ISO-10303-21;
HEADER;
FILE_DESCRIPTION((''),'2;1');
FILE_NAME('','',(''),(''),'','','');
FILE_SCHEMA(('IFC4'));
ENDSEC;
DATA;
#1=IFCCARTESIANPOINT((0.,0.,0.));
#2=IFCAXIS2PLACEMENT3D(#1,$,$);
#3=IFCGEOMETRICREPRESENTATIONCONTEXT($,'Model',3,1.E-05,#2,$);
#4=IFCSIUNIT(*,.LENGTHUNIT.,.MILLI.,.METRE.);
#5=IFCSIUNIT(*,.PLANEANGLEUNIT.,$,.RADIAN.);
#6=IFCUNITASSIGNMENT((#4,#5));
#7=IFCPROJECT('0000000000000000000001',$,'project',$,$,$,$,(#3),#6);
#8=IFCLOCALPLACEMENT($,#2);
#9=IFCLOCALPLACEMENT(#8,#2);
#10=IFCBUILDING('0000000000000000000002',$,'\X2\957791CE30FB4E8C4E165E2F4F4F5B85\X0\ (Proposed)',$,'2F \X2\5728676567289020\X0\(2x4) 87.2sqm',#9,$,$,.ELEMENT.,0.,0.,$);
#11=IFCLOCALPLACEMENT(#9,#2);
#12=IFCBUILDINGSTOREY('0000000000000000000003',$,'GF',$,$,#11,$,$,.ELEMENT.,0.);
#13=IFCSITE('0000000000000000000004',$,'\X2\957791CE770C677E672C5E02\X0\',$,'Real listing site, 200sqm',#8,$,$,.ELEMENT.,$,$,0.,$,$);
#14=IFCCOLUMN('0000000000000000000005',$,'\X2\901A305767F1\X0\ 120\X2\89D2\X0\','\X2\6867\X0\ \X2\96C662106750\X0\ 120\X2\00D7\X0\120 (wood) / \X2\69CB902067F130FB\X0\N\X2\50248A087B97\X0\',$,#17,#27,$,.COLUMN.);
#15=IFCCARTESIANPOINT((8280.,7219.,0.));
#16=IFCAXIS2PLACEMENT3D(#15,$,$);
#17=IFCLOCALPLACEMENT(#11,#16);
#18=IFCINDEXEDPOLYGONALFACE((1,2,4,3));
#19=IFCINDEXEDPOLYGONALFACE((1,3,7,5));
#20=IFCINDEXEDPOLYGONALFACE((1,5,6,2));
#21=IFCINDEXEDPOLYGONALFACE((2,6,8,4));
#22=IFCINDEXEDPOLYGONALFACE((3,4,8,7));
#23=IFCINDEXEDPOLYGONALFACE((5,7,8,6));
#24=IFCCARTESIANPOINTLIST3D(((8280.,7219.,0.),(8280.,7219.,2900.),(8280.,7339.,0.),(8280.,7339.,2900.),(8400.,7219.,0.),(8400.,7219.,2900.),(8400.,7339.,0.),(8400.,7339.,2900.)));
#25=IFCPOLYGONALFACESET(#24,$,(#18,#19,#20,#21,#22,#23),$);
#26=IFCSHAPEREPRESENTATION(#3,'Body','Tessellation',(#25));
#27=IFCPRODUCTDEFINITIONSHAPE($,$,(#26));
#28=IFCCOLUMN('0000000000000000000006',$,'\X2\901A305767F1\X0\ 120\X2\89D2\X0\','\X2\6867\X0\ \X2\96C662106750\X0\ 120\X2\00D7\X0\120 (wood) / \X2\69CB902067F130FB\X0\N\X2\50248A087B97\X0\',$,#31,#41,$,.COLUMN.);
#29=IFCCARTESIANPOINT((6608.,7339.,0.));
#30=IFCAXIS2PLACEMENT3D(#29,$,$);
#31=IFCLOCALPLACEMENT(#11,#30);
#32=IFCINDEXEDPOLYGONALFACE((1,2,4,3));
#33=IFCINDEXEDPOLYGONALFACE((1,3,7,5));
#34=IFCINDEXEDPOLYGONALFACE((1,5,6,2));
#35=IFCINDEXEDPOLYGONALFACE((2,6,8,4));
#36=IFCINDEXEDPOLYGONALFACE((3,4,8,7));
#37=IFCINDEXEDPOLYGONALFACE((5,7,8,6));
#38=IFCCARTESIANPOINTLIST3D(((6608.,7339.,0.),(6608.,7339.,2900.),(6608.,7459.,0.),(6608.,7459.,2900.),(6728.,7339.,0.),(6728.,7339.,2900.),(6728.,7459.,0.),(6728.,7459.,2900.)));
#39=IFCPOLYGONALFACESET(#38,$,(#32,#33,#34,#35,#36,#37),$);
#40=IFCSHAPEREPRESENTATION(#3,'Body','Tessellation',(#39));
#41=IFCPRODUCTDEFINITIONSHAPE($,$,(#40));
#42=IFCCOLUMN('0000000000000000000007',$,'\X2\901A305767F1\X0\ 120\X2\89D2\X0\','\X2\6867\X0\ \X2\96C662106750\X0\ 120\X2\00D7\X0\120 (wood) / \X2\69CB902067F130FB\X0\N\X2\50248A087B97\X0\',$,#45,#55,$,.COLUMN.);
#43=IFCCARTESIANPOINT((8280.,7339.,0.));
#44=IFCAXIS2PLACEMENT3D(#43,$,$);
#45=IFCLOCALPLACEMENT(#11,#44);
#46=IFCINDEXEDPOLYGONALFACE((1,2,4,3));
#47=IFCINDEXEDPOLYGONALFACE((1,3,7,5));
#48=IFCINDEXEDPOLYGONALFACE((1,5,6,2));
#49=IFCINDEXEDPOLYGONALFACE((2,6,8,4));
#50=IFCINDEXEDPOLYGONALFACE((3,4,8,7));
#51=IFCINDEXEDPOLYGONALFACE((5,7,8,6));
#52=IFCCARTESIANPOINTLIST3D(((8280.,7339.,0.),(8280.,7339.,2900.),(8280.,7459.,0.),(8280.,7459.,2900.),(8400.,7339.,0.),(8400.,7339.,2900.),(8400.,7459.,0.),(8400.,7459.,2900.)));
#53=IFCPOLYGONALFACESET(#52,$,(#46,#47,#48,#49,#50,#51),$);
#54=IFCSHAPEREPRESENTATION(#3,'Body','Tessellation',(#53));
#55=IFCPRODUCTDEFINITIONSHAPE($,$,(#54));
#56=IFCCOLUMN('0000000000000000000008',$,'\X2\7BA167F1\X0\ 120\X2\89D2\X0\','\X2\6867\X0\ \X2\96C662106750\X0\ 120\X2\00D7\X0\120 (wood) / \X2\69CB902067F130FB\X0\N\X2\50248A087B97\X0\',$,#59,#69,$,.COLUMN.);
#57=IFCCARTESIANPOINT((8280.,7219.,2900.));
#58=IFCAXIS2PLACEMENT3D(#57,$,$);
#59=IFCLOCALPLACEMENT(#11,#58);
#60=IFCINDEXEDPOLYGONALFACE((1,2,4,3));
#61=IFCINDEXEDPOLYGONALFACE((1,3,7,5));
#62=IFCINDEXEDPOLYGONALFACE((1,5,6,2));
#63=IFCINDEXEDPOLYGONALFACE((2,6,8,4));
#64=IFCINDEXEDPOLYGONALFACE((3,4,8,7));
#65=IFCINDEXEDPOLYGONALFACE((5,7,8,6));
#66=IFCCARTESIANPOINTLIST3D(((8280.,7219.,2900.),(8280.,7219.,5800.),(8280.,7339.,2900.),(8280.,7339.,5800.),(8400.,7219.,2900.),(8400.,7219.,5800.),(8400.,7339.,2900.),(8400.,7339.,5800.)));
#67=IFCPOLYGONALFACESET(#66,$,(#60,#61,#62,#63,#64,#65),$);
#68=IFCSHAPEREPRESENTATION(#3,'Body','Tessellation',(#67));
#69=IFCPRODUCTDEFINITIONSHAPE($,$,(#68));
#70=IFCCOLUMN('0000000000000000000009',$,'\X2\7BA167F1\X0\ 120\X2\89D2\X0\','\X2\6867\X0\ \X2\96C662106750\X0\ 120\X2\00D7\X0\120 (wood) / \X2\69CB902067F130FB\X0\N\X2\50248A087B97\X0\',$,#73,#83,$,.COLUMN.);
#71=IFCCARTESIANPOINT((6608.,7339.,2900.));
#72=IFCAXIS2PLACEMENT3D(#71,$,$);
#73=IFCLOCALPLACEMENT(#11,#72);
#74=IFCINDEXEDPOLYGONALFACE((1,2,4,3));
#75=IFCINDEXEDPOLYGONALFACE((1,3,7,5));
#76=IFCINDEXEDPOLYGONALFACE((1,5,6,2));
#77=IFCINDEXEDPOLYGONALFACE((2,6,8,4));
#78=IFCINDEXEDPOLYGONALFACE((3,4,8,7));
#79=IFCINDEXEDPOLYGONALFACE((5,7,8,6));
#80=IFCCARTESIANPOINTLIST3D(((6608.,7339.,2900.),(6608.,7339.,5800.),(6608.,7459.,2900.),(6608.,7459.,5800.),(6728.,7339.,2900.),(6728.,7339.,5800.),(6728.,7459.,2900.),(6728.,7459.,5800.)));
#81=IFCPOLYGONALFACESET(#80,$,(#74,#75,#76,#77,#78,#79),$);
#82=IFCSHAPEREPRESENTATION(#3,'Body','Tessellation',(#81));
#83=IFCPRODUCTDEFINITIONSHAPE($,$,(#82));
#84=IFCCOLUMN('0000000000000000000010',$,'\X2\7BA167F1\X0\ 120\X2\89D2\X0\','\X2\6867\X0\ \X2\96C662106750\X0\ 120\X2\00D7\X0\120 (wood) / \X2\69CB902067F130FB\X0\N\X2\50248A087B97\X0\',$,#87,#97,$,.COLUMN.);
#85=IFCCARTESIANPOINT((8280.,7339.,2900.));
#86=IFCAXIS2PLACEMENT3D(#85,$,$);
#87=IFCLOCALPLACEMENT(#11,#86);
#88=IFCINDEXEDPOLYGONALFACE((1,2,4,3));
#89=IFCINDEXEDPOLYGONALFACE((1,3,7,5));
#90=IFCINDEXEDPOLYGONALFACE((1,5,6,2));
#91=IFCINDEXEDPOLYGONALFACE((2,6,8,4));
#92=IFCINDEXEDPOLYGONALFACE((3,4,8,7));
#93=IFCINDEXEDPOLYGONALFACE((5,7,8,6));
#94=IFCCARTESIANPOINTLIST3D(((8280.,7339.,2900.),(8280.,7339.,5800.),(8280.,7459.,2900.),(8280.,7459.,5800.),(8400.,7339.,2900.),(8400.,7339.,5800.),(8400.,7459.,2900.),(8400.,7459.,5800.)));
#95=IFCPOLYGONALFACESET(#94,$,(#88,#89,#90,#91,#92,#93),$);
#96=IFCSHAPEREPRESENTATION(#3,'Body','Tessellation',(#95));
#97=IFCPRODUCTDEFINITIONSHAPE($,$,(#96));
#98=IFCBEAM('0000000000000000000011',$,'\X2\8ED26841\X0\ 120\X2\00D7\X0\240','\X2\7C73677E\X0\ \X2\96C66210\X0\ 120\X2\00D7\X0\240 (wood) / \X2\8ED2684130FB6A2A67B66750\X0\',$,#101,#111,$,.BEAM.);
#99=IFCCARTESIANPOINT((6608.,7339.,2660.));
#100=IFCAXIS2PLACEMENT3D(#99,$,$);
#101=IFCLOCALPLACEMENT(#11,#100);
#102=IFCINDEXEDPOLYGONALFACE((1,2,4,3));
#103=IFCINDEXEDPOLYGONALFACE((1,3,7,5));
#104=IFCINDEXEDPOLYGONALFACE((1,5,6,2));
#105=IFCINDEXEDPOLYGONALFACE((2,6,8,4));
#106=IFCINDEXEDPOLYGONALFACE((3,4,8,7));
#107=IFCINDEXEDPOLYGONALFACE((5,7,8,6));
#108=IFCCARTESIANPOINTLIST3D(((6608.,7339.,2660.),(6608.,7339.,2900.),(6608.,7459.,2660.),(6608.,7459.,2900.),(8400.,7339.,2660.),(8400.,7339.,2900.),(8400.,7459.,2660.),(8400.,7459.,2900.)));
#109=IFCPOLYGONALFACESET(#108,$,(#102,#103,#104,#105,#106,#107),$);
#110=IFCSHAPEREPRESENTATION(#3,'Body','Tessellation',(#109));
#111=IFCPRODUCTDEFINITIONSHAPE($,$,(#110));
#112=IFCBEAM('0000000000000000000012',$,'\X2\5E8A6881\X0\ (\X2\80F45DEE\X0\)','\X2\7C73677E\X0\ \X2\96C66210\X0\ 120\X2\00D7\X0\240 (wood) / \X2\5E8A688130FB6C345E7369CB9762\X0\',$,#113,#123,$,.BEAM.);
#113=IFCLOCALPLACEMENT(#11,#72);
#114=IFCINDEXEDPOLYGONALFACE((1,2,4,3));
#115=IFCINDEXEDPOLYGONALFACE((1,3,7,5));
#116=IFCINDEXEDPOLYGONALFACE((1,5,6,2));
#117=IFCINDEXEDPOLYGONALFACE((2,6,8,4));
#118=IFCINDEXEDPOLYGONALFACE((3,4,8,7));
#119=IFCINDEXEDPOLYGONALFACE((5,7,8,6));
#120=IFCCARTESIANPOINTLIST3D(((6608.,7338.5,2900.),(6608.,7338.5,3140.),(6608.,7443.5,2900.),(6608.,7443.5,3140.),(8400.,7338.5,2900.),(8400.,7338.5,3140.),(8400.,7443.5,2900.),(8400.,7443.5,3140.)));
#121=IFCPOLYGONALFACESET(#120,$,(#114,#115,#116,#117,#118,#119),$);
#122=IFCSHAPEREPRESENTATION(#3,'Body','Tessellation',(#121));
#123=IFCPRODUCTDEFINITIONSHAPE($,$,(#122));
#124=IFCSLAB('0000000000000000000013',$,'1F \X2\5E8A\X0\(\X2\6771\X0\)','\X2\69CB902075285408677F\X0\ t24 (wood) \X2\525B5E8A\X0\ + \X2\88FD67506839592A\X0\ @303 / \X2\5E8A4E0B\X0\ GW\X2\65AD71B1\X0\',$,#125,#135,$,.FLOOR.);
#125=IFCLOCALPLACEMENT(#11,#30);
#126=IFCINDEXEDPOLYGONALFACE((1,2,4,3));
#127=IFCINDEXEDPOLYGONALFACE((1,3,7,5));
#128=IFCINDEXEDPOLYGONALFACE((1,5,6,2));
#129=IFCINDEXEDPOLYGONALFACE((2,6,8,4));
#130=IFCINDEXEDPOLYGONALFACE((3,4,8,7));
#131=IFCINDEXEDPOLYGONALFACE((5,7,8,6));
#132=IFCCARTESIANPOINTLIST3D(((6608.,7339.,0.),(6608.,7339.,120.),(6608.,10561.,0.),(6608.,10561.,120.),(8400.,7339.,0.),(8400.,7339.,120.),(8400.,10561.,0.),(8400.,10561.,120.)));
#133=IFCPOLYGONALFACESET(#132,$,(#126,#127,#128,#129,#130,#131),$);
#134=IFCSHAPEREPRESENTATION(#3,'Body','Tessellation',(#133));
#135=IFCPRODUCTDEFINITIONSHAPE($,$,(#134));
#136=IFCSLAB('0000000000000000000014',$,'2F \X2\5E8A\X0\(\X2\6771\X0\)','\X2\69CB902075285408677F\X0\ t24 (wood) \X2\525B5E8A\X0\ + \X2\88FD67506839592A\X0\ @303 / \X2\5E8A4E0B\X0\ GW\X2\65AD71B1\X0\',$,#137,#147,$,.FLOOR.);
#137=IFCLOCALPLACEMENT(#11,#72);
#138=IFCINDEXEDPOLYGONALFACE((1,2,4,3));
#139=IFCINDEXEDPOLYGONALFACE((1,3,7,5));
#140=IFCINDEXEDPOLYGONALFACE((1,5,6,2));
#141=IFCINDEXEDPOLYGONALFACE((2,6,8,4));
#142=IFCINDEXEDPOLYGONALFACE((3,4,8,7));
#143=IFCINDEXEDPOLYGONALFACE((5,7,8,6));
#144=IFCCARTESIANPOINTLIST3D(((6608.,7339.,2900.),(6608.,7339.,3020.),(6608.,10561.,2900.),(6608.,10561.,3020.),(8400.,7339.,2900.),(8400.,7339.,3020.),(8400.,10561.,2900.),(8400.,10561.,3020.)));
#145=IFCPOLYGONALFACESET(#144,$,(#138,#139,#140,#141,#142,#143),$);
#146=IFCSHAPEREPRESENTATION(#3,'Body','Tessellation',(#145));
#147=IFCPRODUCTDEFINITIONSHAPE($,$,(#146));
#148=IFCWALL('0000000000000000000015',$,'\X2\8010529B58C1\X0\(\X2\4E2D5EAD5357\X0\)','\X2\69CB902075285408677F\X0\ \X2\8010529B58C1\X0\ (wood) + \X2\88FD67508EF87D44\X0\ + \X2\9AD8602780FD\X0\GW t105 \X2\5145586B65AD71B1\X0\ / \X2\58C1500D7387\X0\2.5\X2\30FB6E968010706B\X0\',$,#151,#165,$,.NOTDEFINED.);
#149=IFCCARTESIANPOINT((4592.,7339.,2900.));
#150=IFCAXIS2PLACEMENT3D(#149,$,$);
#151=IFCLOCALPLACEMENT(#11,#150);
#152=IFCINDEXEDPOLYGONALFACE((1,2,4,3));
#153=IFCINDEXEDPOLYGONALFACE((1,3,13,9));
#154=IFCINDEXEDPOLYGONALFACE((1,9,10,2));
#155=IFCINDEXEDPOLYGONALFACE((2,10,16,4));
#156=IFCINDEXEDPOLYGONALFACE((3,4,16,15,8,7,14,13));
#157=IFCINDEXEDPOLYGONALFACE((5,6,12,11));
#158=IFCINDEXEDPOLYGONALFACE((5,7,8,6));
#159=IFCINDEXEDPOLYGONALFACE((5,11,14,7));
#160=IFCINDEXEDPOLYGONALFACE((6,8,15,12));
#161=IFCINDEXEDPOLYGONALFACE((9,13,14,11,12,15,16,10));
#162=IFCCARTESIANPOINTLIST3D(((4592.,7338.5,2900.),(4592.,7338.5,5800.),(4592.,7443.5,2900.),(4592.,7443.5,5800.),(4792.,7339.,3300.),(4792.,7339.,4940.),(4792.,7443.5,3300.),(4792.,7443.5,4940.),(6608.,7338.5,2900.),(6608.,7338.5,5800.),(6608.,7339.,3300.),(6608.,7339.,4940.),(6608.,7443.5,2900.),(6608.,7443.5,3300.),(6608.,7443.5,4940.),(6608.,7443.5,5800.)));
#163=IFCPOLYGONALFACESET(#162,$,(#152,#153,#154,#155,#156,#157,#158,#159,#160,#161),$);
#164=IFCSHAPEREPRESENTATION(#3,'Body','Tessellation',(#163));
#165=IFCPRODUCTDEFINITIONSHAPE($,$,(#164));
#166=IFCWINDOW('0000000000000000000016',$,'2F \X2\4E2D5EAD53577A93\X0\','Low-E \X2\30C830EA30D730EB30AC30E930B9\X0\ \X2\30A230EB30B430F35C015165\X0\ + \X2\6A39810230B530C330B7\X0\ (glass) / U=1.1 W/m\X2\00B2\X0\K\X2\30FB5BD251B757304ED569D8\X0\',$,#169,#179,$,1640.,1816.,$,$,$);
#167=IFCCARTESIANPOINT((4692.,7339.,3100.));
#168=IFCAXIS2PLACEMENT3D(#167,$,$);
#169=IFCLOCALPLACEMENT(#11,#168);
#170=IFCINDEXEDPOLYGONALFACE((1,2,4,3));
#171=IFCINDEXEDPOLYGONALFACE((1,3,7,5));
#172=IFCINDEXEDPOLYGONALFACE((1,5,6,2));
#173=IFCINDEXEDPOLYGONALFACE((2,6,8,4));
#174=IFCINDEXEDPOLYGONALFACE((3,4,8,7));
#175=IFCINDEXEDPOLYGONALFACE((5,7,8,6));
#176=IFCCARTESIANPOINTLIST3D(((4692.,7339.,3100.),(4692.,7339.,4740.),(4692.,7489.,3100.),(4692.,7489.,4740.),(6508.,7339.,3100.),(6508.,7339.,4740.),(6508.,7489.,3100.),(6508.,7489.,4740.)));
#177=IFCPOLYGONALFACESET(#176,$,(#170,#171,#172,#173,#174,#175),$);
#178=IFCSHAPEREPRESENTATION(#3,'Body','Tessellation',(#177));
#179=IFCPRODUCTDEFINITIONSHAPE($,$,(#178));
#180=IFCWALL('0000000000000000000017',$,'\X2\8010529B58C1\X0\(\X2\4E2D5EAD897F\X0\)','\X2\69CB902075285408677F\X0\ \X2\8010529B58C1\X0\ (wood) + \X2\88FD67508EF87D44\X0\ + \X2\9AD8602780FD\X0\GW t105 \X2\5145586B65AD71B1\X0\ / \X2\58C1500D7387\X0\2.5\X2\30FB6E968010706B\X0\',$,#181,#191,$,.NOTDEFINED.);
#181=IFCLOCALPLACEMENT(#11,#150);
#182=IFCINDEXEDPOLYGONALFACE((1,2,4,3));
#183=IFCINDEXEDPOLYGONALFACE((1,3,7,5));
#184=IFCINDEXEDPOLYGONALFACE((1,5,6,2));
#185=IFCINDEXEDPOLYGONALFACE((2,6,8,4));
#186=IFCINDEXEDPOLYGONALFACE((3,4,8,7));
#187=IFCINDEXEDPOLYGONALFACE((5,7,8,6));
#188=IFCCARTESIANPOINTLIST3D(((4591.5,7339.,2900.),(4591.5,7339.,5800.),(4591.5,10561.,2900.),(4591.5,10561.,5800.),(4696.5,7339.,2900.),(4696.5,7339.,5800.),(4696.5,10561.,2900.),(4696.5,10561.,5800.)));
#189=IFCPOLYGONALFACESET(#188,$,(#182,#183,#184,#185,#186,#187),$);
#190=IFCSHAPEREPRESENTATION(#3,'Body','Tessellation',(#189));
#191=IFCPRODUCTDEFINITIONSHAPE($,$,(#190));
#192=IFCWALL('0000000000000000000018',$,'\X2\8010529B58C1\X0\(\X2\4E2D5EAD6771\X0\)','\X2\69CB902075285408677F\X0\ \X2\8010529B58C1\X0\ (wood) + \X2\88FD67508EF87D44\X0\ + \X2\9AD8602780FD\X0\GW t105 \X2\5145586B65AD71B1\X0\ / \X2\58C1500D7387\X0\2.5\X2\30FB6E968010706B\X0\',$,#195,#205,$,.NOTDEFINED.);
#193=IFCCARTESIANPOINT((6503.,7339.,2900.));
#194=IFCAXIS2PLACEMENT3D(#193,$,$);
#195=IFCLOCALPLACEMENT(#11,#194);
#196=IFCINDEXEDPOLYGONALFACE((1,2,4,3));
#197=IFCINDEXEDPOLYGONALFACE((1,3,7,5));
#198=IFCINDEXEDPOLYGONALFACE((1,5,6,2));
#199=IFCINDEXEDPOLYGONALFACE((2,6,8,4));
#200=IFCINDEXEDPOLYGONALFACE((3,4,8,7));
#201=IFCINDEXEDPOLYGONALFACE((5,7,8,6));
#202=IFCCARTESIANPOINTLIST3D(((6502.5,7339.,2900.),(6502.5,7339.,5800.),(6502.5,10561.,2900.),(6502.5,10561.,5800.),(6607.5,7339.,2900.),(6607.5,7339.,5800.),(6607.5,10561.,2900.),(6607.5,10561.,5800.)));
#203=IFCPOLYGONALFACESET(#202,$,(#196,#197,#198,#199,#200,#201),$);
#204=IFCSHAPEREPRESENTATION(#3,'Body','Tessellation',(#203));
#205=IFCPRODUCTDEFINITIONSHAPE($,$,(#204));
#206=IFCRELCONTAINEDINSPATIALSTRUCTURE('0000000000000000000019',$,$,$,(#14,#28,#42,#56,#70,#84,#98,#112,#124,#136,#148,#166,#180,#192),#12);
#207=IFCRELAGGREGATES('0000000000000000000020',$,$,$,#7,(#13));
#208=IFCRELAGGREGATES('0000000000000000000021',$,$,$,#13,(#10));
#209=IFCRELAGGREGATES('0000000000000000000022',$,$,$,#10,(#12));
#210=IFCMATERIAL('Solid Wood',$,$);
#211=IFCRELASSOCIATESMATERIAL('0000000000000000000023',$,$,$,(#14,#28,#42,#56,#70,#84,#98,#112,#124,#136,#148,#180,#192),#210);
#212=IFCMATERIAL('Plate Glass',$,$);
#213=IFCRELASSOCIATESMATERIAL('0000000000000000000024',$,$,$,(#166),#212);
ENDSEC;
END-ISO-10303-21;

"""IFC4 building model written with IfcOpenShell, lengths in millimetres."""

from ifc_helpers import new_model, si_unit, frame, frame_2d, origin, place, context, project, spatial, rectangle, extrude, material, element, fill, save


model = new_model("IFC4")

# Units and contexts
model_context = context("Model", 3, precision=1e-05, world=origin())
ifc_project = project(units=[si_unit("LENGTHUNIT", "METRE", prefix="MILLI"), si_unit("PLANEANGLEUNIT", "RADIAN")], contexts=[model_context])

# Site, building, storey
site_placement = place(None, origin())
site = spatial("IfcSite", under=ifc_project, at=site_placement, Name="長野県松本市", ObjectType="Real listing site, 200sqm", CompositionType="ELEMENT", RefElevation=0.0)
building_placement = place(site_placement, origin())
building = spatial("IfcBuilding", under=site, at=building_placement, Name="長野・二世帯住宅 (Proposed)", ObjectType="2F 在来木造(2x4) 87.2sqm", CompositionType="ELEMENT", ElevationOfRefHeight=0.0, ElevationOfTerrain=0.0)
storey_placement = place(building_placement, origin())
storey = spatial("IfcBuildingStorey", under=building, at=storey_placement, Name="GF", CompositionType="ELEMENT", Elevation=0.0)

# Columns
ifc_material_1 = material(Name="Solid Wood")
column_1_placement = place(storey_placement, frame((8280.0, 7219.0, 0.0)))
element("IfcColumn", 1, at=column_1_placement, inside=storey, material=ifc_material_1, Name="通し柱 120角", Description="桧 集成材 120×120 (wood) / 構造柱・N値計算", PredefinedType="COLUMN", context=model_context, shape_type="SweptSolid", body=[
    extrude(rectangle(XDim=120.0, YDim=120.0, at=frame_2d((60.0, 60.0))), frame((8280.0, 7219.0, 0.0)), (0.0, 0.0, 1.0), 2900.0),
])
column_2_placement = place(storey_placement, frame((6608.0, 7339.0, 0.0)))
element("IfcColumn", 2, at=column_2_placement, inside=storey, material=ifc_material_1, Name="通し柱 120角", Description="桧 集成材 120×120 (wood) / 構造柱・N値計算", PredefinedType="COLUMN", context=model_context, shape_type="SweptSolid", body=[
    extrude(rectangle(XDim=120.0, YDim=120.0, at=frame_2d((60.0, 60.0))), frame((6608.0, 7339.0, 0.0)), (0.0, 0.0, 1.0), 2900.0),
])
column_3_placement = place(storey_placement, frame((8280.0, 7339.0, 0.0)))
element("IfcColumn", 3, at=column_3_placement, inside=storey, material=ifc_material_1, Name="通し柱 120角", Description="桧 集成材 120×120 (wood) / 構造柱・N値計算", PredefinedType="COLUMN", context=model_context, shape_type="SweptSolid", body=[
    extrude(rectangle(XDim=120.0, YDim=120.0, at=frame_2d((60.0, 60.0))), frame((8280.0, 7339.0, 0.0)), (0.0, 0.0, 1.0), 2900.0),
])
column_4_placement = place(storey_placement, frame((8280.0, 7219.0, 2900.0)))
element("IfcColumn", 4, at=column_4_placement, inside=storey, material=ifc_material_1, Name="管柱 120角", Description="桧 集成材 120×120 (wood) / 構造柱・N値計算", PredefinedType="COLUMN", context=model_context, shape_type="SweptSolid", body=[
    extrude(rectangle(XDim=120.0, YDim=120.0, at=frame_2d((60.0, 60.0))), frame((8280.0, 7219.0, 2900.0)), (0.0, 0.0, 1.0), 2900.0),
])
column_5_placement = place(storey_placement, frame((6608.0, 7339.0, 2900.0)))
element("IfcColumn", 5, at=column_5_placement, inside=storey, material=ifc_material_1, Name="管柱 120角", Description="桧 集成材 120×120 (wood) / 構造柱・N値計算", PredefinedType="COLUMN", context=model_context, shape_type="SweptSolid", body=[
    extrude(rectangle(XDim=120.0, YDim=120.0, at=frame_2d((60.0, 60.0))), frame((6608.0, 7339.0, 2900.0)), (0.0, 0.0, 1.0), 2900.0),
])
column_6_placement = place(storey_placement, frame((8280.0, 7339.0, 2900.0)))
element("IfcColumn", 6, at=column_6_placement, inside=storey, material=ifc_material_1, Name="管柱 120角", Description="桧 集成材 120×120 (wood) / 構造柱・N値計算", PredefinedType="COLUMN", context=model_context, shape_type="SweptSolid", body=[
    extrude(rectangle(XDim=120.0, YDim=120.0, at=frame_2d((60.0, 60.0))), frame((8280.0, 7339.0, 2900.0)), (0.0, 0.0, 1.0), 2900.0),
])

# Beams
beam_1_placement = place(storey_placement, frame((6608.0, 7339.0, 2660.0)))
element("IfcBeam", 7, at=beam_1_placement, inside=storey, material=ifc_material_1, Name="軒桁 120×240", Description="米松 集成 120×240 (wood) / 軒桁・横架材", PredefinedType="BEAM", context=model_context, shape_type="SweptSolid", body=[
    extrude(rectangle(XDim=1792.0, YDim=120.0, at=frame_2d((896.0, 60.0))), frame((6608.0, 7339.0, 2660.0)), (0.0, 0.0, 1.0), 240.0),
])
beam_2_placement = place(storey_placement, frame((6608.0, 7339.0, 2900.0)))
element("IfcBeam", 8, at=beam_2_placement, inside=storey, material=ifc_material_1, Name="床梁 (胴差)", Description="米松 集成 120×240 (wood) / 床梁・水平構面", PredefinedType="BEAM", context=model_context, shape_type="SweptSolid", body=[
    extrude(rectangle(XDim=1792.0, YDim=105.0, at=frame_2d((896.0, 52.0))), frame((6608.0, 7339.0, 2900.0)), (0.0, 0.0, 1.0), 240.0),
])

# Slabs
slab_1_placement = place(storey_placement, frame((6608.0, 7339.0, 0.0)))
element("IfcSlab", 9, at=slab_1_placement, inside=storey, material=ifc_material_1, Name="1F 床(東)", Description="構造用合板 t24 (wood) 剛床 + 製材根太 @303 / 床下 GW断熱", PredefinedType="FLOOR", context=model_context, shape_type="SweptSolid", body=[
    extrude(rectangle(XDim=1792.0, YDim=3222.0, at=frame_2d((896.0, 1611.0))), frame((6608.0, 7339.0, 0.0)), (0.0, 0.0, 1.0), 120.0),
])
slab_2_placement = place(storey_placement, frame((6608.0, 7339.0, 2900.0)))
element("IfcSlab", 10, at=slab_2_placement, inside=storey, material=ifc_material_1, Name="2F 床(東)", Description="構造用合板 t24 (wood) 剛床 + 製材根太 @303 / 床下 GW断熱", PredefinedType="FLOOR", context=model_context, shape_type="SweptSolid", body=[
    extrude(rectangle(XDim=1792.0, YDim=3222.0, at=frame_2d((896.0, 1611.0))), frame((6608.0, 7339.0, 2900.0)), (0.0, 0.0, 1.0), 120.0),
])

# Wall, opening, window
wall_1_placement = place(storey_placement, frame((4592.0, 7339.0, 2900.0)))
wall_1 = element("IfcWall", 11, at=wall_1_placement, inside=storey, material=ifc_material_1, Name="耐力壁(中庭南)", Description="構造用合板 耐力壁 (wood) + 製材軸組 + 高性能GW t105 充填断熱 / 壁倍率2.5・準耐火", PredefinedType="NOTDEFINED", context=model_context, shape_type="SweptSolid", body=[
    extrude(rectangle(XDim=2016.0, YDim=105.0, at=frame_2d((1008.0, 52.0))), frame((4592.0, 7339.0, 2900.0)), (0.0, 0.0, 1.0), 2900.0),
])
opening_placement = place(storey_placement, frame((4692.0, 7339.0, 3100.0)))
opening = element("IfcOpeningElement", 12, at=opening_placement, cuts=wall_1, PredefinedType="NOTDEFINED", context=model_context, shape_type="SweptSolid", body=[
    extrude(rectangle(XDim=1816.0, YDim=150.0, at=frame_2d((908.0, 75.0))), frame((4692.0, 7339.0, 3100.0)), (0.0, 0.0, 1.0), 1640.0),
])
ifc_material_2 = material(Name="Plate Glass")
window_1_placement = place(storey_placement, frame((4692.0, 7339.0, 3100.0)))
window_1 = element("IfcWindow", 13, at=window_1_placement, inside=storey, material=ifc_material_2, Name="2F 中庭南窓", Description="Low-E トリプルガラス アルゴン封入 + 樹脂サッシ (glass) / U=1.1 W/m²K・寒冷地仕様", OverallHeight=1640.0, OverallWidth=1816.0, context=model_context, shape_type="SweptSolid", body=[
    extrude(rectangle(XDim=1816.0, YDim=150.0, at=frame_2d((908.0, 75.0))), frame((4692.0, 7339.0, 3100.0)), (0.0, 0.0, 1.0), 1640.0),
])
fill(opening, window_1)

# Walls
wall_2_placement = place(storey_placement, frame((4592.0, 7339.0, 2900.0)))
element("IfcWall", 14, at=wall_2_placement, inside=storey, material=ifc_material_1, Name="耐力壁(中庭西)", Description="構造用合板 耐力壁 (wood) + 製材軸組 + 高性能GW t105 充填断熱 / 壁倍率2.5・準耐火", PredefinedType="NOTDEFINED", context=model_context, shape_type="SweptSolid", body=[
    extrude(rectangle(XDim=105.0, YDim=3222.0, at=frame_2d((52.0, 1611.0))), frame((4592.0, 7339.0, 2900.0)), (0.0, 0.0, 1.0), 2900.0),
])
wall_3_placement = place(storey_placement, frame((6503.0, 7339.0, 2900.0)))
element("IfcWall", 15, at=wall_3_placement, inside=storey, material=ifc_material_1, Name="耐力壁(中庭東)", Description="構造用合板 耐力壁 (wood) + 製材軸組 + 高性能GW t105 充填断熱 / 壁倍率2.5・準耐火", PredefinedType="NOTDEFINED", context=model_context, shape_type="SweptSolid", body=[
    extrude(rectangle(XDim=105.0, YDim=3222.0, at=frame_2d((52.0, 1611.0))), frame((6503.0, 7339.0, 2900.0)), (0.0, 0.0, 1.0), 2900.0),
])

save(model, "model.ifc")
